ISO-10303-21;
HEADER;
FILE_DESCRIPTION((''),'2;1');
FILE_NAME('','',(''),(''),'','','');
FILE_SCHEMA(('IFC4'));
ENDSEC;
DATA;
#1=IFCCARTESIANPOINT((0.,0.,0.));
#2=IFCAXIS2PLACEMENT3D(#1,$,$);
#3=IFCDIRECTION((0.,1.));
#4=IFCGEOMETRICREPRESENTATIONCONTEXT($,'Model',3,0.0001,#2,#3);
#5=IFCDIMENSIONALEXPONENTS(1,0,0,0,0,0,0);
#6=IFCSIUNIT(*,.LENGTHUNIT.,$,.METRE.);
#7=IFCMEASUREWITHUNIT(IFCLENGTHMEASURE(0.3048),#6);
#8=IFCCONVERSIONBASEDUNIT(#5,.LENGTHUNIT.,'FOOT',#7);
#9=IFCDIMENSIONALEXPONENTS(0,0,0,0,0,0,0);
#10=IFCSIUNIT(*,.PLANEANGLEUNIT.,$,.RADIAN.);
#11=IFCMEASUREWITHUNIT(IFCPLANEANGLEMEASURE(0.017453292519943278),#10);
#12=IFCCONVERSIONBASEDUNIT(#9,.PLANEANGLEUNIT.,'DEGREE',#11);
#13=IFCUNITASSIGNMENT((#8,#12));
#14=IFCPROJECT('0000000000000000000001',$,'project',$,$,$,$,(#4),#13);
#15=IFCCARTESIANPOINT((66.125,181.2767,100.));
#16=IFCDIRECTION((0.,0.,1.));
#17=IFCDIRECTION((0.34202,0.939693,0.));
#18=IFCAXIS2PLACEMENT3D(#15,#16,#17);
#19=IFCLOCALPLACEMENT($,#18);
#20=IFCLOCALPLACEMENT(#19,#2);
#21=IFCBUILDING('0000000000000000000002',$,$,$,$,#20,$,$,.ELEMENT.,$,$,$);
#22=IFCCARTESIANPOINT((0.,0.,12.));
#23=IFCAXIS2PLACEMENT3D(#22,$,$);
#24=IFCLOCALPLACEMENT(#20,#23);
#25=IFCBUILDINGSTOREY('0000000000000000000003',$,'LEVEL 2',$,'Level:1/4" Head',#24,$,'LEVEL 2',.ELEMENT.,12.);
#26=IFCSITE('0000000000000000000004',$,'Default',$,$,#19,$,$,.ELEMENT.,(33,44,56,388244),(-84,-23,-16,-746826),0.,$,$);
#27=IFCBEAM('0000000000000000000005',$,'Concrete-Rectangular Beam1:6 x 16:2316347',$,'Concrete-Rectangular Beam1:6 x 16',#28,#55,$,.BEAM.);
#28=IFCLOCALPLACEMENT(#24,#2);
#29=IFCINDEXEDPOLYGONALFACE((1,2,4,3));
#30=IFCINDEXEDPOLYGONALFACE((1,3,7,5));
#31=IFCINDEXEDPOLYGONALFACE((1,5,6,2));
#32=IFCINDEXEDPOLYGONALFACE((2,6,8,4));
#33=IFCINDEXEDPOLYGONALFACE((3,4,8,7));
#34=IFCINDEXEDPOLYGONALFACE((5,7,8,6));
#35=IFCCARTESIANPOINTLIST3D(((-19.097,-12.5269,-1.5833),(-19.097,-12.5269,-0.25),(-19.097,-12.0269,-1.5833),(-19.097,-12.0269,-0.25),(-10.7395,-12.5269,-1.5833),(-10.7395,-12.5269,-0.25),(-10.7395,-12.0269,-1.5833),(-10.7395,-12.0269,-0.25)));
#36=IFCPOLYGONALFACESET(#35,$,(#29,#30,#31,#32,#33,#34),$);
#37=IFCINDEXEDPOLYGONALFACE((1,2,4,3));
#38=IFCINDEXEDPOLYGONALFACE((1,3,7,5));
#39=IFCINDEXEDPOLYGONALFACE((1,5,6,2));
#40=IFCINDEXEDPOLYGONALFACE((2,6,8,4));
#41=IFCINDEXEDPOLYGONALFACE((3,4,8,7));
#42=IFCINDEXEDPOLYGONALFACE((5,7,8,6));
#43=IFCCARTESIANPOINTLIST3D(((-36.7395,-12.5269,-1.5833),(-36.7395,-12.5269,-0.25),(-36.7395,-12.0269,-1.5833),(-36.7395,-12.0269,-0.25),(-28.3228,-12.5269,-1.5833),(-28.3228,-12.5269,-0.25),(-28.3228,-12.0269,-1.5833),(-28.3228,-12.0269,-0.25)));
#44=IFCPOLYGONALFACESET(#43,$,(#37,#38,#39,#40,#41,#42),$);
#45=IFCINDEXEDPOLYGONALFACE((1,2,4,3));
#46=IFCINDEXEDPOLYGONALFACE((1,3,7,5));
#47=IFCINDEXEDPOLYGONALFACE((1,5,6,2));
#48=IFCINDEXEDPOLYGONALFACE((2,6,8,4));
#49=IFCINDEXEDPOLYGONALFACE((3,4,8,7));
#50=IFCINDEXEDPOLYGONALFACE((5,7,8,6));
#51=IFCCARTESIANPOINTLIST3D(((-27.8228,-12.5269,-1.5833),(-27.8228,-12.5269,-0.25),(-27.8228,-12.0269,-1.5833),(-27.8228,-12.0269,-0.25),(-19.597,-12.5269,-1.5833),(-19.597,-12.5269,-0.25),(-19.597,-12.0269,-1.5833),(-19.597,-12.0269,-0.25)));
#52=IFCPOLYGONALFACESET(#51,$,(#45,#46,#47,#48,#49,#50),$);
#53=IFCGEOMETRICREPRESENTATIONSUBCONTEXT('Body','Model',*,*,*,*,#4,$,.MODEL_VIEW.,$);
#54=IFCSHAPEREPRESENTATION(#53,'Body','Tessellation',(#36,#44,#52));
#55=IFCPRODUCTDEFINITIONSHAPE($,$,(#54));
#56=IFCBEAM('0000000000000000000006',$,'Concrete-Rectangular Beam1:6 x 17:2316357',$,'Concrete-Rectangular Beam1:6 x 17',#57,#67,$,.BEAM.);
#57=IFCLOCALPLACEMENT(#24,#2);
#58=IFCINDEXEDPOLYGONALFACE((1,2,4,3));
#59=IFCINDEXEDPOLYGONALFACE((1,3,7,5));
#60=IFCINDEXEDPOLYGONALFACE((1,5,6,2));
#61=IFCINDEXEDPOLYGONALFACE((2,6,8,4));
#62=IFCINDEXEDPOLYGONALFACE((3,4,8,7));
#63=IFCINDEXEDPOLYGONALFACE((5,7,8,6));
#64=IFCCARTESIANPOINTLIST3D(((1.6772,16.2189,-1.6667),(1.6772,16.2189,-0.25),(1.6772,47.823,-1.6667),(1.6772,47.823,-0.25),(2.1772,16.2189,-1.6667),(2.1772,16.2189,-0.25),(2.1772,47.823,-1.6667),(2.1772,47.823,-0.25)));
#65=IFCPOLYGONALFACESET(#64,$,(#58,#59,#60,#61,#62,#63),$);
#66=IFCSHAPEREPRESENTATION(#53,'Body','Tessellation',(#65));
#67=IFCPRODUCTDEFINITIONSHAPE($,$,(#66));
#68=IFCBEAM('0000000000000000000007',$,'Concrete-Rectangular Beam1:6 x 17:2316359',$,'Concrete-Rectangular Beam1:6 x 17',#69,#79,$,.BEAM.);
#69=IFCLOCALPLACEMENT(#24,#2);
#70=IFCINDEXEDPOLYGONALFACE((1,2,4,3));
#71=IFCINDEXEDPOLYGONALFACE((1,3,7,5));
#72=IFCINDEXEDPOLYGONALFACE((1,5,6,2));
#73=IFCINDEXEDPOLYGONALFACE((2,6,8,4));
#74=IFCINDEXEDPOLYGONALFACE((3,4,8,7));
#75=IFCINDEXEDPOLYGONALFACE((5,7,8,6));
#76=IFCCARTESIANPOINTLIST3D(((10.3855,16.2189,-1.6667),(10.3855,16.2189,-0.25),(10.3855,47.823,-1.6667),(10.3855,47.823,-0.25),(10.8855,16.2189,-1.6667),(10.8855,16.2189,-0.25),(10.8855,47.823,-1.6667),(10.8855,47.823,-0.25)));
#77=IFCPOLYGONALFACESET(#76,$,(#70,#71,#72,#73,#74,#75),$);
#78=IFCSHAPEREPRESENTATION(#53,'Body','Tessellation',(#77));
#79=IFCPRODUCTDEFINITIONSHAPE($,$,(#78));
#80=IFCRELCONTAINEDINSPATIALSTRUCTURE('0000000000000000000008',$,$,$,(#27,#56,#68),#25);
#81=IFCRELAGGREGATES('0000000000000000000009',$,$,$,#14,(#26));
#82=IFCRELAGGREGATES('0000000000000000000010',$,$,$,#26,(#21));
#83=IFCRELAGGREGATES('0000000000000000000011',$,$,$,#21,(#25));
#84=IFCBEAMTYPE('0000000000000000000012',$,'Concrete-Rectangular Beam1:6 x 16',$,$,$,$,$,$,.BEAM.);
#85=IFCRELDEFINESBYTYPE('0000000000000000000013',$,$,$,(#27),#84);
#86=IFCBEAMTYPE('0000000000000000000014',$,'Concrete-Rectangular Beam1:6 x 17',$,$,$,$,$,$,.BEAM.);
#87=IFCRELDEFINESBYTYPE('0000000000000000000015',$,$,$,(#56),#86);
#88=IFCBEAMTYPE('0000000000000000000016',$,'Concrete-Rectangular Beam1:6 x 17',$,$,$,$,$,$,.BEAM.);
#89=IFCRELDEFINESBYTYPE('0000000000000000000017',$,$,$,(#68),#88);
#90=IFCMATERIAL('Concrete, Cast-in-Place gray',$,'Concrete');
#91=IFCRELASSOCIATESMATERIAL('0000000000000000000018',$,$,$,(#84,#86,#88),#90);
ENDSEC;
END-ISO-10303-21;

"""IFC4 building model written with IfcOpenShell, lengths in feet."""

from ifc_helpers import new_model, entity, si_unit, converted_unit, direction, frame, frame_2d, origin, place, context, subcontext, project, spatial, rectangle, extrude, source, transform, mapped, material, material_profile, profile_set, type_object, type_shapes, element, save


model = new_model("IFC4")

# Units and contexts
model_context = context("Model", 3, precision=0.0001, world=origin(), true_north=direction((0.0, 1.0)))
body_context = subcontext(model_context, "Body", "Model", "MODEL_VIEW")
ifc_project = project(units=[converted_unit("LENGTHUNIT", "FOOT", entity("IfcLengthMeasure", 0.3048), si_unit("LENGTHUNIT", "METRE"), dimensions=[1, 0, 0, 0, 0, 0, 0]), converted_unit("PLANEANGLEUNIT", "DEGREE", entity("IfcPlaneAngleMeasure", 0.017453292519943278), si_unit("PLANEANGLEUNIT", "RADIAN"), dimensions=[0, 0, 0, 0, 0, 0, 0])], contexts=[model_context])

# Site, building, storey
site_placement = place(None, frame((66.125, 181.2767, 100.0), z_axis=(0.0, 0.0, 1.0), x_axis=(0.34202, 0.939693, 0.0)))
site = spatial("IfcSite", under=ifc_project, at=site_placement, Name="Default", CompositionType="ELEMENT", RefLatitude=(33, 44, 56, 388244), RefLongitude=(-84, -23, -16, -746826), RefElevation=0.0)
building_placement = place(site_placement, origin())
building = spatial("IfcBuilding", under=site, at=building_placement, CompositionType="ELEMENT")
storey_placement = place(building_placement, frame((0.0, 0.0, 12.0)))
storey = spatial("IfcBuildingStorey", under=building, at=storey_placement, Name="LEVEL 2", ObjectType="Level:1/4\" Head", LongName="LEVEL 2", CompositionType="ELEMENT", Elevation=12.0)

# Beams
ifc_material = material(Name="Concrete, Cast-in-Place gray", Category="Concrete")
ifc_material_profile_1 = material_profile(ifc_material, rectangle(XDim=1.3333, YDim=0.5, at=frame_2d((0.0, 0.0), x_axis=(1.0, 0.0))), Name="6 x 16")
ifc_profile_set_1 = profile_set([ifc_material_profile_1], Name="6 x 16")
beam_type_1 = type_object("IfcBeamType", Name="Concrete-Rectangular Beam1:6 x 16", PredefinedType="BEAM", material=ifc_profile_set_1)
shared_shape_1 = source(origin(), body_context, "Body", "SweptSolid", [
    extrude(rectangle(XDim=1.3333, YDim=0.5, at=frame_2d((0.0, 0.0), x_axis=(1.0, 0.0))), frame((-19.097, -12.2769, 11.0833), z_axis=(1.0, 0.0, 0.0), x_axis=(0.0, 0.0, -1.0)), (0.0, 0.0, 1.0), 8.3575),
    extrude(rectangle(XDim=1.3333, YDim=0.5, at=frame_2d((0.0, 0.0), x_axis=(1.0, 0.0))), frame((-36.7395, -12.2769, 11.0833), z_axis=(1.0, 0.0, 0.0), x_axis=(0.0, 0.0, -1.0)), (0.0, 0.0, 1.0), 8.4167),
    extrude(rectangle(XDim=1.3333, YDim=0.5, at=frame_2d((0.0, 0.0), x_axis=(1.0, 0.0))), frame((-27.8228, -12.2769, 11.0833), z_axis=(1.0, 0.0, 0.0), x_axis=(0.0, 0.0, -1.0)), (0.0, 0.0, 1.0), 8.2258),
])
type_shapes(beam_type_1, [shared_shape_1])
beam_1_placement = place(storey_placement, frame((0.0, 0.0, -12.0)))
element("IfcBeam", 1, at=beam_1_placement, inside=storey, type_object=beam_type_1, Name="Concrete-Rectangular Beam1:6 x 16:2316347", ObjectType="Concrete-Rectangular Beam1:6 x 16", PredefinedType="BEAM", context=body_context, shape_type="MappedRepresentation", body=[
    mapped(shared_shape_1, transform((0.0, 0.0, 0.0), scale=1.0)),
])
ifc_material_profile_2 = material_profile(ifc_material, rectangle(XDim=1.4167, YDim=0.5, at=frame_2d((0.0, 0.0), x_axis=(0.0, 1.0))), Name="6 x 17")
ifc_profile_set_2 = profile_set([ifc_material_profile_2], Name="6 x 17")
beam_type_2 = type_object("IfcBeamType", Name="Concrete-Rectangular Beam1:6 x 17", PredefinedType="BEAM", material=ifc_profile_set_2)
shared_shape_2 = source(origin(), body_context, "Body", "SweptSolid", [
    extrude(rectangle(XDim=1.4167, YDim=0.5, at=frame_2d((0.0, 0.0), x_axis=(0.0, 1.0))), frame((1.9272, 47.823, 11.0417), z_axis=(0.0, -1.0, 0.0), x_axis=(-1.0, 0.0, 0.0)), (0.0, 0.0, 1.0), 31.6042),
])
type_shapes(beam_type_2, [shared_shape_2])
beam_2_placement = place(storey_placement, frame((0.0, 0.0, -12.0)))
element("IfcBeam", 2, at=beam_2_placement, inside=storey, type_object=beam_type_2, Name="Concrete-Rectangular Beam1:6 x 17:2316357", ObjectType="Concrete-Rectangular Beam1:6 x 17", PredefinedType="BEAM", context=body_context, shape_type="MappedRepresentation", body=[
    mapped(shared_shape_2, transform((0.0, 0.0, 0.0), scale=1.0)),
])
beam_type_3 = type_object("IfcBeamType", Name="Concrete-Rectangular Beam1:6 x 17", PredefinedType="BEAM", material=ifc_profile_set_2)
shared_shape_3 = source(origin(), body_context, "Body", "SweptSolid", [
    extrude(rectangle(XDim=1.4167, YDim=0.5, at=frame_2d((0.0, 0.0), x_axis=(0.0, 1.0))), frame((10.6355, 47.823, 11.0417), z_axis=(0.0, -1.0, 0.0), x_axis=(-1.0, 0.0, 0.0)), (0.0, 0.0, 1.0), 31.6042),
])
type_shapes(beam_type_3, [shared_shape_3])
beam_3_placement = place(storey_placement, frame((0.0, 0.0, -12.0)))
element("IfcBeam", 3, at=beam_3_placement, inside=storey, type_object=beam_type_3, Name="Concrete-Rectangular Beam1:6 x 17:2316359", ObjectType="Concrete-Rectangular Beam1:6 x 17", PredefinedType="BEAM", context=body_context, shape_type="MappedRepresentation", body=[
    mapped(shared_shape_3, transform((0.0, 0.0, 0.0), scale=1.0)),
])

save(model, "model.ifc")
